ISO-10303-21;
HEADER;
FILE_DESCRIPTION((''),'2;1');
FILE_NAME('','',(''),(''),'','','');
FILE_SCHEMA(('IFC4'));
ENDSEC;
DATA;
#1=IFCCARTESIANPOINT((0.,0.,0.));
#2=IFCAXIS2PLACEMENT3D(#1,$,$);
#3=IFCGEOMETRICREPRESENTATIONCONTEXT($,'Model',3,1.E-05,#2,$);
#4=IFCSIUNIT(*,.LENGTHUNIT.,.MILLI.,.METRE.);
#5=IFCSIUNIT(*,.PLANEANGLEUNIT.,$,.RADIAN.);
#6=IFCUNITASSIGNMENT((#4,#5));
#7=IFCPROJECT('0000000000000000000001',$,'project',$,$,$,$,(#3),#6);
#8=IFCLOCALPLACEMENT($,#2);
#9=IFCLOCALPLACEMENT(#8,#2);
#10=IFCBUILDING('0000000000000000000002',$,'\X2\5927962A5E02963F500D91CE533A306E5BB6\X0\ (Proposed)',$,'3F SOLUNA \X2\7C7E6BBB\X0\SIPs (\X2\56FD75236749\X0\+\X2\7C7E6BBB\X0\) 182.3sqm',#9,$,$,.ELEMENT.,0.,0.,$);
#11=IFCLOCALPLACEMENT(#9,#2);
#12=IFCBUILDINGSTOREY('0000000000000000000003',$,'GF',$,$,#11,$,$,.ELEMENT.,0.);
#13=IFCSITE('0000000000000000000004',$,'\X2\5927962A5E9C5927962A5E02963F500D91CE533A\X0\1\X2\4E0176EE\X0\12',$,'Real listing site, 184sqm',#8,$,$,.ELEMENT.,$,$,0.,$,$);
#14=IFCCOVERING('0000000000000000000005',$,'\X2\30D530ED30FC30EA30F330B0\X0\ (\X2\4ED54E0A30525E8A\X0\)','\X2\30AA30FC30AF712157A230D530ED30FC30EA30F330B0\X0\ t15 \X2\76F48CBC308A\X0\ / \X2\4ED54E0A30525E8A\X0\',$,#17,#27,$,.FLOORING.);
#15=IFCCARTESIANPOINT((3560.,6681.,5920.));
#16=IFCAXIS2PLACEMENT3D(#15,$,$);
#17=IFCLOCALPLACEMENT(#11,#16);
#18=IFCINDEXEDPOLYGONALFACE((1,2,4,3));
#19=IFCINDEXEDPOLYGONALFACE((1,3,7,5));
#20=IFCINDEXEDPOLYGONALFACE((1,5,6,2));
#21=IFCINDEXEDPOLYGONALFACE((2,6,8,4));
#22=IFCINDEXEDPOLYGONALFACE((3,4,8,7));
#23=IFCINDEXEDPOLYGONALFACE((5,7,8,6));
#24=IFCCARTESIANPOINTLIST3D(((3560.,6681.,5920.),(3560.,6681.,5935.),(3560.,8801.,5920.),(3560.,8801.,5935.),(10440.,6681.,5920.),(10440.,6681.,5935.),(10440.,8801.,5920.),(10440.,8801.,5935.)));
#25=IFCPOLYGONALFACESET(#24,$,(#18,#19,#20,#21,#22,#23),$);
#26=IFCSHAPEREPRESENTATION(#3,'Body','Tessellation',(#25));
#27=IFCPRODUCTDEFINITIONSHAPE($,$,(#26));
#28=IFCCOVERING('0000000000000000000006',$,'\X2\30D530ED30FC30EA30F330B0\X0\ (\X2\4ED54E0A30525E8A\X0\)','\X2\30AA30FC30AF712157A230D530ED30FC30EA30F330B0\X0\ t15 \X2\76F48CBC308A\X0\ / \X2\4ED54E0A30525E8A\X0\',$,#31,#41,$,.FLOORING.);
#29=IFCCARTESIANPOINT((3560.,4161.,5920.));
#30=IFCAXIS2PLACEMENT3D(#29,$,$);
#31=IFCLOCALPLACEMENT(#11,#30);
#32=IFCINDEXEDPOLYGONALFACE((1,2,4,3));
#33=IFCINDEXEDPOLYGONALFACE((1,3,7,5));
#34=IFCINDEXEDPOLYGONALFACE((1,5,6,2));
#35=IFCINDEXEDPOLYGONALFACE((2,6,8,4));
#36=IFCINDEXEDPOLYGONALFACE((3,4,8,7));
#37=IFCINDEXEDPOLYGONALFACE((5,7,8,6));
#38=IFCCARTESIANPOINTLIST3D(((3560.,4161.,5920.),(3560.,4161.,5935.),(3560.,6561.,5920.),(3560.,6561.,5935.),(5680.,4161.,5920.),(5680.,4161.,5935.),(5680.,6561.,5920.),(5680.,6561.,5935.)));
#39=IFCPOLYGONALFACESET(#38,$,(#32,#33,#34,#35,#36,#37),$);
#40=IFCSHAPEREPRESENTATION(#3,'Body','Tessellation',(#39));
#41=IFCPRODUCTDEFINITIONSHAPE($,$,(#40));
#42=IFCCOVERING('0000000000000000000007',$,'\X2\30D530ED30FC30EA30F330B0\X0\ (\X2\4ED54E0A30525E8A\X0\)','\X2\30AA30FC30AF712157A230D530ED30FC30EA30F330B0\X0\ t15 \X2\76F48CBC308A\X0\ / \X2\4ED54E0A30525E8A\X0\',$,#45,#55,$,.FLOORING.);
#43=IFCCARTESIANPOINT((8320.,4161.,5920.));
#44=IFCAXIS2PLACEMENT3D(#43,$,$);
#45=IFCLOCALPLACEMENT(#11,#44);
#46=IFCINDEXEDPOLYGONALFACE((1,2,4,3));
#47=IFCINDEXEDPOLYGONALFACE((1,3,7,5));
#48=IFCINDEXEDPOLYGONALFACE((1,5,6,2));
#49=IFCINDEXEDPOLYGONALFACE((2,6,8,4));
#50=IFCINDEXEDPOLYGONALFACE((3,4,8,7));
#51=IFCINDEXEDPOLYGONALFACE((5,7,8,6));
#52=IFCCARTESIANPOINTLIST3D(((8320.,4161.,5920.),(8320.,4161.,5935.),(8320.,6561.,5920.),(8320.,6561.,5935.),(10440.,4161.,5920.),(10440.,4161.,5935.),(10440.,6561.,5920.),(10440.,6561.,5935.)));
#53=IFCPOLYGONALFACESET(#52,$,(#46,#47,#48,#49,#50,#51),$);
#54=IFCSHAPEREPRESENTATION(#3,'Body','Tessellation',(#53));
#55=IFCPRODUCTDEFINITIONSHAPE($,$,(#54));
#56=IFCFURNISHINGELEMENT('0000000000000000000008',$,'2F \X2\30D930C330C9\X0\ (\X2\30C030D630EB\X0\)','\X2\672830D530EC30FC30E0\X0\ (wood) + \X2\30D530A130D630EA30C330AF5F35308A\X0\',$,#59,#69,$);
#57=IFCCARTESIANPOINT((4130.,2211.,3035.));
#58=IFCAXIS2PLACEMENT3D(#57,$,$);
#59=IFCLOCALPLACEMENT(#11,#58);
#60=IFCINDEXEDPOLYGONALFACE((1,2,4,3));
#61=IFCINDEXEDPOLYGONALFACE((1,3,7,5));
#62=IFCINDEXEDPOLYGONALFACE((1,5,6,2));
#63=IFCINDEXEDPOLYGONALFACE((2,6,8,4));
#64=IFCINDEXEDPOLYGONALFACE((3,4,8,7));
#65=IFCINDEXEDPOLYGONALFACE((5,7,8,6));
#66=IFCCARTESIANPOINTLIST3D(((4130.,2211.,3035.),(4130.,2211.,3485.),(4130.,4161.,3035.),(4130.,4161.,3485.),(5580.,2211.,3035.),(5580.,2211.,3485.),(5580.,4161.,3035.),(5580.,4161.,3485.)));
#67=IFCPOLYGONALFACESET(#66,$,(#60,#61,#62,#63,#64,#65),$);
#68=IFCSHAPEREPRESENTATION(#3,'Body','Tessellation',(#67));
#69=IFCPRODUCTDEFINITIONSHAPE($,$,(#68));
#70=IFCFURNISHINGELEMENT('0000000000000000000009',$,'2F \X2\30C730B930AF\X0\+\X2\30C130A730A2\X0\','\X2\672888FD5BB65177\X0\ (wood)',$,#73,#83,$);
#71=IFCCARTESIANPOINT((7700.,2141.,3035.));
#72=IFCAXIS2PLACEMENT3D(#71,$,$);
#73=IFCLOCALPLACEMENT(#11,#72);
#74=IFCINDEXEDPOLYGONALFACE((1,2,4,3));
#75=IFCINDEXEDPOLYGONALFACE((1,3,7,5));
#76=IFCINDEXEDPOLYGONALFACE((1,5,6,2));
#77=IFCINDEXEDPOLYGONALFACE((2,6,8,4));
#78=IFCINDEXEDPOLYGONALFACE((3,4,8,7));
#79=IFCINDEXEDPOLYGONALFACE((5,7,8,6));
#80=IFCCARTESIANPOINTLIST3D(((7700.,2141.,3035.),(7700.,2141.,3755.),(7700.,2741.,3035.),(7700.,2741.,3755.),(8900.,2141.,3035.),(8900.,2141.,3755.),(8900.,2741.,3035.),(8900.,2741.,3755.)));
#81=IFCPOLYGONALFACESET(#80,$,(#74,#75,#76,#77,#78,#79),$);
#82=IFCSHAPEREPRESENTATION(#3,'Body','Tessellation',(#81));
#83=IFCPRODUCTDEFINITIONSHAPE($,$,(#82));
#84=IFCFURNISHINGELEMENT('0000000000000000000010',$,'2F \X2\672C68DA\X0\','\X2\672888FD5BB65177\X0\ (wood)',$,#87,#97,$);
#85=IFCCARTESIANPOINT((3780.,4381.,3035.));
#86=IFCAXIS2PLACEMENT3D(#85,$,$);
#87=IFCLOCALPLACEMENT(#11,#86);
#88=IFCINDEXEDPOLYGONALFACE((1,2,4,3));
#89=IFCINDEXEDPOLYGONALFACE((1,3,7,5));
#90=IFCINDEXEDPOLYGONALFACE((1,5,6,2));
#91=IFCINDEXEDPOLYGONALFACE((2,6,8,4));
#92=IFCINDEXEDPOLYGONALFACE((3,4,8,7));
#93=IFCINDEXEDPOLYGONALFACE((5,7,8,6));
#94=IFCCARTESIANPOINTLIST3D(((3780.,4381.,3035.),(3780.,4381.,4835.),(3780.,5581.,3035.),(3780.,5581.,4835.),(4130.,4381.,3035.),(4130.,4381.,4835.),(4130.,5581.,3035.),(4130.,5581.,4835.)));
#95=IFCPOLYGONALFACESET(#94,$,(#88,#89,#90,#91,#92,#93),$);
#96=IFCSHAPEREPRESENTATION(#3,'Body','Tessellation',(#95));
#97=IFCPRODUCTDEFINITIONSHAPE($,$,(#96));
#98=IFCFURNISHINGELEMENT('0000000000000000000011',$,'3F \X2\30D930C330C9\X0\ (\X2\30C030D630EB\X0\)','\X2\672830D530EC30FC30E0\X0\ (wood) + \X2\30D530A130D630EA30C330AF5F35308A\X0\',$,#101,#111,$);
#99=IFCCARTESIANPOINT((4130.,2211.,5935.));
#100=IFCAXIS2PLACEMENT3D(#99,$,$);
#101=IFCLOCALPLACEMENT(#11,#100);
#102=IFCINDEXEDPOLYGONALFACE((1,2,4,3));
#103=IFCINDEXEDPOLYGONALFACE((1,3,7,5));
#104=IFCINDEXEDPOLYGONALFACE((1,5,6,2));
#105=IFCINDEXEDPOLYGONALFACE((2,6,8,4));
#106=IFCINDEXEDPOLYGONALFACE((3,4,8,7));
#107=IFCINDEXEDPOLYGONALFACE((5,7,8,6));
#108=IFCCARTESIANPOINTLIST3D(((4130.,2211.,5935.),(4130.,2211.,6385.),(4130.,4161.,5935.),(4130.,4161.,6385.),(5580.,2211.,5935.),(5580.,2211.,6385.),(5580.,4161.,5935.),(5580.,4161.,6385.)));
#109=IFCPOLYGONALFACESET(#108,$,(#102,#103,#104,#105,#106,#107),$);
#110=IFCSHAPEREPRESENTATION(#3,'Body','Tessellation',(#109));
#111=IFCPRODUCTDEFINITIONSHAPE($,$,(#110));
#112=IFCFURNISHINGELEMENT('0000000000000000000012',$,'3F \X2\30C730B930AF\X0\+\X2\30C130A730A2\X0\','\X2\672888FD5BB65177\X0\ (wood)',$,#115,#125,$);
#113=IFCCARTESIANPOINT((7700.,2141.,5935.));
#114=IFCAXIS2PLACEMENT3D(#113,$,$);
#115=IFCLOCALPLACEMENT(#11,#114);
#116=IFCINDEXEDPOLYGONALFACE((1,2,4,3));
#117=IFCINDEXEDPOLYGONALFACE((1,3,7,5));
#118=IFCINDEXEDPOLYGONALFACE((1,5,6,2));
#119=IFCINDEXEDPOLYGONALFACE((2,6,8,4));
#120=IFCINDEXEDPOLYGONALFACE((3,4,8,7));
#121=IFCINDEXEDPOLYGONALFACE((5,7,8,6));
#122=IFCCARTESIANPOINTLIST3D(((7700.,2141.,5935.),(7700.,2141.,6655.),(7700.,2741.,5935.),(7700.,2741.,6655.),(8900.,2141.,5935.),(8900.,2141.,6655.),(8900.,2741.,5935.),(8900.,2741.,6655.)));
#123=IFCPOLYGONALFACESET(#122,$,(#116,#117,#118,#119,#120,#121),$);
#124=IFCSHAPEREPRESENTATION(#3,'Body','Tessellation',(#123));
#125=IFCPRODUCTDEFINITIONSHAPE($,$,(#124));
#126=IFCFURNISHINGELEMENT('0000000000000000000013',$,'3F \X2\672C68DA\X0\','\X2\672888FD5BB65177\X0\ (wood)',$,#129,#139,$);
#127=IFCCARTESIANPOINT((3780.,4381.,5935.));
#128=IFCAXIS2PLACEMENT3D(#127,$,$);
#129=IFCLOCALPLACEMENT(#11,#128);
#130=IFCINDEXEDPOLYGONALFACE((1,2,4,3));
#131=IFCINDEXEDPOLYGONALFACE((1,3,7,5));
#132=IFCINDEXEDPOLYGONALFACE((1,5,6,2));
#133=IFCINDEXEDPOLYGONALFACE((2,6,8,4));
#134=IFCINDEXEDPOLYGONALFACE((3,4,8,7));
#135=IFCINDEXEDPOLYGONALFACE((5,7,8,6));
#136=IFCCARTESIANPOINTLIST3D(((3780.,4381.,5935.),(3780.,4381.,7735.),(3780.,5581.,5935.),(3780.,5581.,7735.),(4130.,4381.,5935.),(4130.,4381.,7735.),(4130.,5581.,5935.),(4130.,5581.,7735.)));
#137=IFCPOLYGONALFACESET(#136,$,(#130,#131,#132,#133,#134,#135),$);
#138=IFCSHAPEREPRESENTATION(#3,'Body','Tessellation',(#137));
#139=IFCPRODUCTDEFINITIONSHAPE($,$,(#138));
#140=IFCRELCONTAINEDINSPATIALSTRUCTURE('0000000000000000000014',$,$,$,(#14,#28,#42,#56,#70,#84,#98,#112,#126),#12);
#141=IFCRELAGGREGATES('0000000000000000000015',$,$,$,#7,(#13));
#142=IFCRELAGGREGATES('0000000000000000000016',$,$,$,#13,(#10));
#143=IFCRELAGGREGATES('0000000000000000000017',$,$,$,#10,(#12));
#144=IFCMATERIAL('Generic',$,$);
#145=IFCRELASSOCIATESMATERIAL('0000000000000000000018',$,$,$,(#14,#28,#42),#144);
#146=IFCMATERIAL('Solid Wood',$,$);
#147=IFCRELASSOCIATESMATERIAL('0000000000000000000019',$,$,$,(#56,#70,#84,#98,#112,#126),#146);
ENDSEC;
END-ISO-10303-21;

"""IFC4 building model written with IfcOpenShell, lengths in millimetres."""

from ifc_helpers import new_model, si_unit, frame, frame_2d, origin, place, context, project, spatial, rectangle, extrude, material, element, save


model = new_model("IFC4")

# Units and contexts
model_context = context("Model", 3, precision=1e-05, world=origin())
ifc_project = project(units=[si_unit("LENGTHUNIT", "METRE", prefix="MILLI"), si_unit("PLANEANGLEUNIT", "RADIAN")], contexts=[model_context])

# Site, building, storey
site_placement = place(None, origin())
site = spatial("IfcSite", under=ifc_project, at=site_placement, Name="大阪府大阪市阿倍野区1丁目12", ObjectType="Real listing site, 184sqm", CompositionType="ELEMENT", RefElevation=0.0)
building_placement = place(site_placement, origin())
building = spatial("IfcBuilding", under=site, at=building_placement, Name="大阪市阿倍野区の家 (Proposed)", ObjectType="3F SOLUNA 籾殻SIPs (国産杉+籾殻) 182.3sqm", CompositionType="ELEMENT", ElevationOfRefHeight=0.0, ElevationOfTerrain=0.0)
storey_placement = place(building_placement, origin())
storey = spatial("IfcBuildingStorey", under=building, at=storey_placement, Name="GF", CompositionType="ELEMENT", Elevation=0.0)

# Shared definitions
ifc_material_1 = material(Name="Solid Wood")

# Shared definitions
ifc_material_2 = material(Name="Generic")

# Coverings
covering_1_placement = place(storey_placement, frame((3560.0, 6681.0, 5920.0)))
element("IfcCovering", 1, at=covering_1_placement, inside=storey, material=ifc_material_2, Name="フローリング (仕上げ床)", Description="オーク無垢フローリング t15 直貼り / 仕上げ床", PredefinedType="FLOORING", context=model_context, shape_type="SweptSolid", body=[
    extrude(rectangle(XDim=6880.0, YDim=2120.0, at=frame_2d((3440.0, 1060.0))), frame((3560.0, 6681.0, 5920.0)), (0.0, 0.0, 1.0), 15.0),
])
covering_2_placement = place(storey_placement, frame((3560.0, 4161.0, 5920.0)))
element("IfcCovering", 2, at=covering_2_placement, inside=storey, material=ifc_material_2, Name="フローリング (仕上げ床)", Description="オーク無垢フローリング t15 直貼り / 仕上げ床", PredefinedType="FLOORING", context=model_context, shape_type="SweptSolid", body=[
    extrude(rectangle(XDim=2120.0, YDim=2400.0, at=frame_2d((1060.0, 1200.0))), frame((3560.0, 4161.0, 5920.0)), (0.0, 0.0, 1.0), 15.0),
])
covering_3_placement = place(storey_placement, frame((8320.0, 4161.0, 5920.0)))
element("IfcCovering", 3, at=covering_3_placement, inside=storey, material=ifc_material_2, Name="フローリング (仕上げ床)", Description="オーク無垢フローリング t15 直貼り / 仕上げ床", PredefinedType="FLOORING", context=model_context, shape_type="SweptSolid", body=[
    extrude(rectangle(XDim=2120.0, YDim=2400.0, at=frame_2d((1060.0, 1200.0))), frame((8320.0, 4161.0, 5920.0)), (0.0, 0.0, 1.0), 15.0),
])

# Furnishing elements
furnishing_1_placement = place(storey_placement, frame((4130.0, 2211.0, 3035.0)))
element("IfcFurnishingElement", 4, at=furnishing_1_placement, inside=storey, material=ifc_material_1, Name="2F ベッド (ダブル)", Description="木フレーム (wood) + ファブリック張り", context=model_context, shape_type="SweptSolid", body=[
    extrude(rectangle(XDim=1450.0, YDim=1950.0, at=frame_2d((725.0, 975.0))), frame((4130.0, 2211.0, 3035.0)), (0.0, 0.0, 1.0), 450.0),
])
furnishing_2_placement = place(storey_placement, frame((7700.0, 2141.0, 3035.0)))
element("IfcFurnishingElement", 5, at=furnishing_2_placement, inside=storey, material=ifc_material_1, Name="2F デスク+チェア", Description="木製家具 (wood)", context=model_context, shape_type="SweptSolid", body=[
    extrude(rectangle(XDim=1200.0, YDim=600.0, at=frame_2d((600.0, 300.0))), frame((7700.0, 2141.0, 3035.0)), (0.0, 0.0, 1.0), 720.0),
])
furnishing_3_placement = place(storey_placement, frame((3780.0, 4381.0, 3035.0)))
element("IfcFurnishingElement", 6, at=furnishing_3_placement, inside=storey, material=ifc_material_1, Name="2F 本棚", Description="木製家具 (wood)", context=model_context, shape_type="SweptSolid", body=[
    extrude(rectangle(XDim=350.0, YDim=1200.0, at=frame_2d((175.0, 600.0))), frame((3780.0, 4381.0, 3035.0)), (0.0, 0.0, 1.0), 1800.0),
])
furnishing_4_placement = place(storey_placement, frame((4130.0, 2211.0, 5935.0)))
element("IfcFurnishingElement", 7, at=furnishing_4_placement, inside=storey, material=ifc_material_1, Name="3F ベッド (ダブル)", Description="木フレーム (wood) + ファブリック張り", context=model_context, shape_type="SweptSolid", body=[
    extrude(rectangle(XDim=1450.0, YDim=1950.0, at=frame_2d((725.0, 975.0))), frame((4130.0, 2211.0, 5935.0)), (0.0, 0.0, 1.0), 450.0),
])
furnishing_5_placement = place(storey_placement, frame((7700.0, 2141.0, 5935.0)))
element("IfcFurnishingElement", 8, at=furnishing_5_placement, inside=storey, material=ifc_material_1, Name="3F デスク+チェア", Description="木製家具 (wood)", context=model_context, shape_type="SweptSolid", body=[
    extrude(rectangle(XDim=1200.0, YDim=600.0, at=frame_2d((600.0, 300.0))), frame((7700.0, 2141.0, 5935.0)), (0.0, 0.0, 1.0), 720.0),
])
furnishing_6_placement = place(storey_placement, frame((3780.0, 4381.0, 5935.0)))
element("IfcFurnishingElement", 9, at=furnishing_6_placement, inside=storey, material=ifc_material_1, Name="3F 本棚", Description="木製家具 (wood)", context=model_context, shape_type="SweptSolid", body=[
    extrude(rectangle(XDim=350.0, YDim=1200.0, at=frame_2d((175.0, 600.0))), frame((3780.0, 4381.0, 5935.0)), (0.0, 0.0, 1.0), 1800.0),
])

save(model, "model.ifc")
